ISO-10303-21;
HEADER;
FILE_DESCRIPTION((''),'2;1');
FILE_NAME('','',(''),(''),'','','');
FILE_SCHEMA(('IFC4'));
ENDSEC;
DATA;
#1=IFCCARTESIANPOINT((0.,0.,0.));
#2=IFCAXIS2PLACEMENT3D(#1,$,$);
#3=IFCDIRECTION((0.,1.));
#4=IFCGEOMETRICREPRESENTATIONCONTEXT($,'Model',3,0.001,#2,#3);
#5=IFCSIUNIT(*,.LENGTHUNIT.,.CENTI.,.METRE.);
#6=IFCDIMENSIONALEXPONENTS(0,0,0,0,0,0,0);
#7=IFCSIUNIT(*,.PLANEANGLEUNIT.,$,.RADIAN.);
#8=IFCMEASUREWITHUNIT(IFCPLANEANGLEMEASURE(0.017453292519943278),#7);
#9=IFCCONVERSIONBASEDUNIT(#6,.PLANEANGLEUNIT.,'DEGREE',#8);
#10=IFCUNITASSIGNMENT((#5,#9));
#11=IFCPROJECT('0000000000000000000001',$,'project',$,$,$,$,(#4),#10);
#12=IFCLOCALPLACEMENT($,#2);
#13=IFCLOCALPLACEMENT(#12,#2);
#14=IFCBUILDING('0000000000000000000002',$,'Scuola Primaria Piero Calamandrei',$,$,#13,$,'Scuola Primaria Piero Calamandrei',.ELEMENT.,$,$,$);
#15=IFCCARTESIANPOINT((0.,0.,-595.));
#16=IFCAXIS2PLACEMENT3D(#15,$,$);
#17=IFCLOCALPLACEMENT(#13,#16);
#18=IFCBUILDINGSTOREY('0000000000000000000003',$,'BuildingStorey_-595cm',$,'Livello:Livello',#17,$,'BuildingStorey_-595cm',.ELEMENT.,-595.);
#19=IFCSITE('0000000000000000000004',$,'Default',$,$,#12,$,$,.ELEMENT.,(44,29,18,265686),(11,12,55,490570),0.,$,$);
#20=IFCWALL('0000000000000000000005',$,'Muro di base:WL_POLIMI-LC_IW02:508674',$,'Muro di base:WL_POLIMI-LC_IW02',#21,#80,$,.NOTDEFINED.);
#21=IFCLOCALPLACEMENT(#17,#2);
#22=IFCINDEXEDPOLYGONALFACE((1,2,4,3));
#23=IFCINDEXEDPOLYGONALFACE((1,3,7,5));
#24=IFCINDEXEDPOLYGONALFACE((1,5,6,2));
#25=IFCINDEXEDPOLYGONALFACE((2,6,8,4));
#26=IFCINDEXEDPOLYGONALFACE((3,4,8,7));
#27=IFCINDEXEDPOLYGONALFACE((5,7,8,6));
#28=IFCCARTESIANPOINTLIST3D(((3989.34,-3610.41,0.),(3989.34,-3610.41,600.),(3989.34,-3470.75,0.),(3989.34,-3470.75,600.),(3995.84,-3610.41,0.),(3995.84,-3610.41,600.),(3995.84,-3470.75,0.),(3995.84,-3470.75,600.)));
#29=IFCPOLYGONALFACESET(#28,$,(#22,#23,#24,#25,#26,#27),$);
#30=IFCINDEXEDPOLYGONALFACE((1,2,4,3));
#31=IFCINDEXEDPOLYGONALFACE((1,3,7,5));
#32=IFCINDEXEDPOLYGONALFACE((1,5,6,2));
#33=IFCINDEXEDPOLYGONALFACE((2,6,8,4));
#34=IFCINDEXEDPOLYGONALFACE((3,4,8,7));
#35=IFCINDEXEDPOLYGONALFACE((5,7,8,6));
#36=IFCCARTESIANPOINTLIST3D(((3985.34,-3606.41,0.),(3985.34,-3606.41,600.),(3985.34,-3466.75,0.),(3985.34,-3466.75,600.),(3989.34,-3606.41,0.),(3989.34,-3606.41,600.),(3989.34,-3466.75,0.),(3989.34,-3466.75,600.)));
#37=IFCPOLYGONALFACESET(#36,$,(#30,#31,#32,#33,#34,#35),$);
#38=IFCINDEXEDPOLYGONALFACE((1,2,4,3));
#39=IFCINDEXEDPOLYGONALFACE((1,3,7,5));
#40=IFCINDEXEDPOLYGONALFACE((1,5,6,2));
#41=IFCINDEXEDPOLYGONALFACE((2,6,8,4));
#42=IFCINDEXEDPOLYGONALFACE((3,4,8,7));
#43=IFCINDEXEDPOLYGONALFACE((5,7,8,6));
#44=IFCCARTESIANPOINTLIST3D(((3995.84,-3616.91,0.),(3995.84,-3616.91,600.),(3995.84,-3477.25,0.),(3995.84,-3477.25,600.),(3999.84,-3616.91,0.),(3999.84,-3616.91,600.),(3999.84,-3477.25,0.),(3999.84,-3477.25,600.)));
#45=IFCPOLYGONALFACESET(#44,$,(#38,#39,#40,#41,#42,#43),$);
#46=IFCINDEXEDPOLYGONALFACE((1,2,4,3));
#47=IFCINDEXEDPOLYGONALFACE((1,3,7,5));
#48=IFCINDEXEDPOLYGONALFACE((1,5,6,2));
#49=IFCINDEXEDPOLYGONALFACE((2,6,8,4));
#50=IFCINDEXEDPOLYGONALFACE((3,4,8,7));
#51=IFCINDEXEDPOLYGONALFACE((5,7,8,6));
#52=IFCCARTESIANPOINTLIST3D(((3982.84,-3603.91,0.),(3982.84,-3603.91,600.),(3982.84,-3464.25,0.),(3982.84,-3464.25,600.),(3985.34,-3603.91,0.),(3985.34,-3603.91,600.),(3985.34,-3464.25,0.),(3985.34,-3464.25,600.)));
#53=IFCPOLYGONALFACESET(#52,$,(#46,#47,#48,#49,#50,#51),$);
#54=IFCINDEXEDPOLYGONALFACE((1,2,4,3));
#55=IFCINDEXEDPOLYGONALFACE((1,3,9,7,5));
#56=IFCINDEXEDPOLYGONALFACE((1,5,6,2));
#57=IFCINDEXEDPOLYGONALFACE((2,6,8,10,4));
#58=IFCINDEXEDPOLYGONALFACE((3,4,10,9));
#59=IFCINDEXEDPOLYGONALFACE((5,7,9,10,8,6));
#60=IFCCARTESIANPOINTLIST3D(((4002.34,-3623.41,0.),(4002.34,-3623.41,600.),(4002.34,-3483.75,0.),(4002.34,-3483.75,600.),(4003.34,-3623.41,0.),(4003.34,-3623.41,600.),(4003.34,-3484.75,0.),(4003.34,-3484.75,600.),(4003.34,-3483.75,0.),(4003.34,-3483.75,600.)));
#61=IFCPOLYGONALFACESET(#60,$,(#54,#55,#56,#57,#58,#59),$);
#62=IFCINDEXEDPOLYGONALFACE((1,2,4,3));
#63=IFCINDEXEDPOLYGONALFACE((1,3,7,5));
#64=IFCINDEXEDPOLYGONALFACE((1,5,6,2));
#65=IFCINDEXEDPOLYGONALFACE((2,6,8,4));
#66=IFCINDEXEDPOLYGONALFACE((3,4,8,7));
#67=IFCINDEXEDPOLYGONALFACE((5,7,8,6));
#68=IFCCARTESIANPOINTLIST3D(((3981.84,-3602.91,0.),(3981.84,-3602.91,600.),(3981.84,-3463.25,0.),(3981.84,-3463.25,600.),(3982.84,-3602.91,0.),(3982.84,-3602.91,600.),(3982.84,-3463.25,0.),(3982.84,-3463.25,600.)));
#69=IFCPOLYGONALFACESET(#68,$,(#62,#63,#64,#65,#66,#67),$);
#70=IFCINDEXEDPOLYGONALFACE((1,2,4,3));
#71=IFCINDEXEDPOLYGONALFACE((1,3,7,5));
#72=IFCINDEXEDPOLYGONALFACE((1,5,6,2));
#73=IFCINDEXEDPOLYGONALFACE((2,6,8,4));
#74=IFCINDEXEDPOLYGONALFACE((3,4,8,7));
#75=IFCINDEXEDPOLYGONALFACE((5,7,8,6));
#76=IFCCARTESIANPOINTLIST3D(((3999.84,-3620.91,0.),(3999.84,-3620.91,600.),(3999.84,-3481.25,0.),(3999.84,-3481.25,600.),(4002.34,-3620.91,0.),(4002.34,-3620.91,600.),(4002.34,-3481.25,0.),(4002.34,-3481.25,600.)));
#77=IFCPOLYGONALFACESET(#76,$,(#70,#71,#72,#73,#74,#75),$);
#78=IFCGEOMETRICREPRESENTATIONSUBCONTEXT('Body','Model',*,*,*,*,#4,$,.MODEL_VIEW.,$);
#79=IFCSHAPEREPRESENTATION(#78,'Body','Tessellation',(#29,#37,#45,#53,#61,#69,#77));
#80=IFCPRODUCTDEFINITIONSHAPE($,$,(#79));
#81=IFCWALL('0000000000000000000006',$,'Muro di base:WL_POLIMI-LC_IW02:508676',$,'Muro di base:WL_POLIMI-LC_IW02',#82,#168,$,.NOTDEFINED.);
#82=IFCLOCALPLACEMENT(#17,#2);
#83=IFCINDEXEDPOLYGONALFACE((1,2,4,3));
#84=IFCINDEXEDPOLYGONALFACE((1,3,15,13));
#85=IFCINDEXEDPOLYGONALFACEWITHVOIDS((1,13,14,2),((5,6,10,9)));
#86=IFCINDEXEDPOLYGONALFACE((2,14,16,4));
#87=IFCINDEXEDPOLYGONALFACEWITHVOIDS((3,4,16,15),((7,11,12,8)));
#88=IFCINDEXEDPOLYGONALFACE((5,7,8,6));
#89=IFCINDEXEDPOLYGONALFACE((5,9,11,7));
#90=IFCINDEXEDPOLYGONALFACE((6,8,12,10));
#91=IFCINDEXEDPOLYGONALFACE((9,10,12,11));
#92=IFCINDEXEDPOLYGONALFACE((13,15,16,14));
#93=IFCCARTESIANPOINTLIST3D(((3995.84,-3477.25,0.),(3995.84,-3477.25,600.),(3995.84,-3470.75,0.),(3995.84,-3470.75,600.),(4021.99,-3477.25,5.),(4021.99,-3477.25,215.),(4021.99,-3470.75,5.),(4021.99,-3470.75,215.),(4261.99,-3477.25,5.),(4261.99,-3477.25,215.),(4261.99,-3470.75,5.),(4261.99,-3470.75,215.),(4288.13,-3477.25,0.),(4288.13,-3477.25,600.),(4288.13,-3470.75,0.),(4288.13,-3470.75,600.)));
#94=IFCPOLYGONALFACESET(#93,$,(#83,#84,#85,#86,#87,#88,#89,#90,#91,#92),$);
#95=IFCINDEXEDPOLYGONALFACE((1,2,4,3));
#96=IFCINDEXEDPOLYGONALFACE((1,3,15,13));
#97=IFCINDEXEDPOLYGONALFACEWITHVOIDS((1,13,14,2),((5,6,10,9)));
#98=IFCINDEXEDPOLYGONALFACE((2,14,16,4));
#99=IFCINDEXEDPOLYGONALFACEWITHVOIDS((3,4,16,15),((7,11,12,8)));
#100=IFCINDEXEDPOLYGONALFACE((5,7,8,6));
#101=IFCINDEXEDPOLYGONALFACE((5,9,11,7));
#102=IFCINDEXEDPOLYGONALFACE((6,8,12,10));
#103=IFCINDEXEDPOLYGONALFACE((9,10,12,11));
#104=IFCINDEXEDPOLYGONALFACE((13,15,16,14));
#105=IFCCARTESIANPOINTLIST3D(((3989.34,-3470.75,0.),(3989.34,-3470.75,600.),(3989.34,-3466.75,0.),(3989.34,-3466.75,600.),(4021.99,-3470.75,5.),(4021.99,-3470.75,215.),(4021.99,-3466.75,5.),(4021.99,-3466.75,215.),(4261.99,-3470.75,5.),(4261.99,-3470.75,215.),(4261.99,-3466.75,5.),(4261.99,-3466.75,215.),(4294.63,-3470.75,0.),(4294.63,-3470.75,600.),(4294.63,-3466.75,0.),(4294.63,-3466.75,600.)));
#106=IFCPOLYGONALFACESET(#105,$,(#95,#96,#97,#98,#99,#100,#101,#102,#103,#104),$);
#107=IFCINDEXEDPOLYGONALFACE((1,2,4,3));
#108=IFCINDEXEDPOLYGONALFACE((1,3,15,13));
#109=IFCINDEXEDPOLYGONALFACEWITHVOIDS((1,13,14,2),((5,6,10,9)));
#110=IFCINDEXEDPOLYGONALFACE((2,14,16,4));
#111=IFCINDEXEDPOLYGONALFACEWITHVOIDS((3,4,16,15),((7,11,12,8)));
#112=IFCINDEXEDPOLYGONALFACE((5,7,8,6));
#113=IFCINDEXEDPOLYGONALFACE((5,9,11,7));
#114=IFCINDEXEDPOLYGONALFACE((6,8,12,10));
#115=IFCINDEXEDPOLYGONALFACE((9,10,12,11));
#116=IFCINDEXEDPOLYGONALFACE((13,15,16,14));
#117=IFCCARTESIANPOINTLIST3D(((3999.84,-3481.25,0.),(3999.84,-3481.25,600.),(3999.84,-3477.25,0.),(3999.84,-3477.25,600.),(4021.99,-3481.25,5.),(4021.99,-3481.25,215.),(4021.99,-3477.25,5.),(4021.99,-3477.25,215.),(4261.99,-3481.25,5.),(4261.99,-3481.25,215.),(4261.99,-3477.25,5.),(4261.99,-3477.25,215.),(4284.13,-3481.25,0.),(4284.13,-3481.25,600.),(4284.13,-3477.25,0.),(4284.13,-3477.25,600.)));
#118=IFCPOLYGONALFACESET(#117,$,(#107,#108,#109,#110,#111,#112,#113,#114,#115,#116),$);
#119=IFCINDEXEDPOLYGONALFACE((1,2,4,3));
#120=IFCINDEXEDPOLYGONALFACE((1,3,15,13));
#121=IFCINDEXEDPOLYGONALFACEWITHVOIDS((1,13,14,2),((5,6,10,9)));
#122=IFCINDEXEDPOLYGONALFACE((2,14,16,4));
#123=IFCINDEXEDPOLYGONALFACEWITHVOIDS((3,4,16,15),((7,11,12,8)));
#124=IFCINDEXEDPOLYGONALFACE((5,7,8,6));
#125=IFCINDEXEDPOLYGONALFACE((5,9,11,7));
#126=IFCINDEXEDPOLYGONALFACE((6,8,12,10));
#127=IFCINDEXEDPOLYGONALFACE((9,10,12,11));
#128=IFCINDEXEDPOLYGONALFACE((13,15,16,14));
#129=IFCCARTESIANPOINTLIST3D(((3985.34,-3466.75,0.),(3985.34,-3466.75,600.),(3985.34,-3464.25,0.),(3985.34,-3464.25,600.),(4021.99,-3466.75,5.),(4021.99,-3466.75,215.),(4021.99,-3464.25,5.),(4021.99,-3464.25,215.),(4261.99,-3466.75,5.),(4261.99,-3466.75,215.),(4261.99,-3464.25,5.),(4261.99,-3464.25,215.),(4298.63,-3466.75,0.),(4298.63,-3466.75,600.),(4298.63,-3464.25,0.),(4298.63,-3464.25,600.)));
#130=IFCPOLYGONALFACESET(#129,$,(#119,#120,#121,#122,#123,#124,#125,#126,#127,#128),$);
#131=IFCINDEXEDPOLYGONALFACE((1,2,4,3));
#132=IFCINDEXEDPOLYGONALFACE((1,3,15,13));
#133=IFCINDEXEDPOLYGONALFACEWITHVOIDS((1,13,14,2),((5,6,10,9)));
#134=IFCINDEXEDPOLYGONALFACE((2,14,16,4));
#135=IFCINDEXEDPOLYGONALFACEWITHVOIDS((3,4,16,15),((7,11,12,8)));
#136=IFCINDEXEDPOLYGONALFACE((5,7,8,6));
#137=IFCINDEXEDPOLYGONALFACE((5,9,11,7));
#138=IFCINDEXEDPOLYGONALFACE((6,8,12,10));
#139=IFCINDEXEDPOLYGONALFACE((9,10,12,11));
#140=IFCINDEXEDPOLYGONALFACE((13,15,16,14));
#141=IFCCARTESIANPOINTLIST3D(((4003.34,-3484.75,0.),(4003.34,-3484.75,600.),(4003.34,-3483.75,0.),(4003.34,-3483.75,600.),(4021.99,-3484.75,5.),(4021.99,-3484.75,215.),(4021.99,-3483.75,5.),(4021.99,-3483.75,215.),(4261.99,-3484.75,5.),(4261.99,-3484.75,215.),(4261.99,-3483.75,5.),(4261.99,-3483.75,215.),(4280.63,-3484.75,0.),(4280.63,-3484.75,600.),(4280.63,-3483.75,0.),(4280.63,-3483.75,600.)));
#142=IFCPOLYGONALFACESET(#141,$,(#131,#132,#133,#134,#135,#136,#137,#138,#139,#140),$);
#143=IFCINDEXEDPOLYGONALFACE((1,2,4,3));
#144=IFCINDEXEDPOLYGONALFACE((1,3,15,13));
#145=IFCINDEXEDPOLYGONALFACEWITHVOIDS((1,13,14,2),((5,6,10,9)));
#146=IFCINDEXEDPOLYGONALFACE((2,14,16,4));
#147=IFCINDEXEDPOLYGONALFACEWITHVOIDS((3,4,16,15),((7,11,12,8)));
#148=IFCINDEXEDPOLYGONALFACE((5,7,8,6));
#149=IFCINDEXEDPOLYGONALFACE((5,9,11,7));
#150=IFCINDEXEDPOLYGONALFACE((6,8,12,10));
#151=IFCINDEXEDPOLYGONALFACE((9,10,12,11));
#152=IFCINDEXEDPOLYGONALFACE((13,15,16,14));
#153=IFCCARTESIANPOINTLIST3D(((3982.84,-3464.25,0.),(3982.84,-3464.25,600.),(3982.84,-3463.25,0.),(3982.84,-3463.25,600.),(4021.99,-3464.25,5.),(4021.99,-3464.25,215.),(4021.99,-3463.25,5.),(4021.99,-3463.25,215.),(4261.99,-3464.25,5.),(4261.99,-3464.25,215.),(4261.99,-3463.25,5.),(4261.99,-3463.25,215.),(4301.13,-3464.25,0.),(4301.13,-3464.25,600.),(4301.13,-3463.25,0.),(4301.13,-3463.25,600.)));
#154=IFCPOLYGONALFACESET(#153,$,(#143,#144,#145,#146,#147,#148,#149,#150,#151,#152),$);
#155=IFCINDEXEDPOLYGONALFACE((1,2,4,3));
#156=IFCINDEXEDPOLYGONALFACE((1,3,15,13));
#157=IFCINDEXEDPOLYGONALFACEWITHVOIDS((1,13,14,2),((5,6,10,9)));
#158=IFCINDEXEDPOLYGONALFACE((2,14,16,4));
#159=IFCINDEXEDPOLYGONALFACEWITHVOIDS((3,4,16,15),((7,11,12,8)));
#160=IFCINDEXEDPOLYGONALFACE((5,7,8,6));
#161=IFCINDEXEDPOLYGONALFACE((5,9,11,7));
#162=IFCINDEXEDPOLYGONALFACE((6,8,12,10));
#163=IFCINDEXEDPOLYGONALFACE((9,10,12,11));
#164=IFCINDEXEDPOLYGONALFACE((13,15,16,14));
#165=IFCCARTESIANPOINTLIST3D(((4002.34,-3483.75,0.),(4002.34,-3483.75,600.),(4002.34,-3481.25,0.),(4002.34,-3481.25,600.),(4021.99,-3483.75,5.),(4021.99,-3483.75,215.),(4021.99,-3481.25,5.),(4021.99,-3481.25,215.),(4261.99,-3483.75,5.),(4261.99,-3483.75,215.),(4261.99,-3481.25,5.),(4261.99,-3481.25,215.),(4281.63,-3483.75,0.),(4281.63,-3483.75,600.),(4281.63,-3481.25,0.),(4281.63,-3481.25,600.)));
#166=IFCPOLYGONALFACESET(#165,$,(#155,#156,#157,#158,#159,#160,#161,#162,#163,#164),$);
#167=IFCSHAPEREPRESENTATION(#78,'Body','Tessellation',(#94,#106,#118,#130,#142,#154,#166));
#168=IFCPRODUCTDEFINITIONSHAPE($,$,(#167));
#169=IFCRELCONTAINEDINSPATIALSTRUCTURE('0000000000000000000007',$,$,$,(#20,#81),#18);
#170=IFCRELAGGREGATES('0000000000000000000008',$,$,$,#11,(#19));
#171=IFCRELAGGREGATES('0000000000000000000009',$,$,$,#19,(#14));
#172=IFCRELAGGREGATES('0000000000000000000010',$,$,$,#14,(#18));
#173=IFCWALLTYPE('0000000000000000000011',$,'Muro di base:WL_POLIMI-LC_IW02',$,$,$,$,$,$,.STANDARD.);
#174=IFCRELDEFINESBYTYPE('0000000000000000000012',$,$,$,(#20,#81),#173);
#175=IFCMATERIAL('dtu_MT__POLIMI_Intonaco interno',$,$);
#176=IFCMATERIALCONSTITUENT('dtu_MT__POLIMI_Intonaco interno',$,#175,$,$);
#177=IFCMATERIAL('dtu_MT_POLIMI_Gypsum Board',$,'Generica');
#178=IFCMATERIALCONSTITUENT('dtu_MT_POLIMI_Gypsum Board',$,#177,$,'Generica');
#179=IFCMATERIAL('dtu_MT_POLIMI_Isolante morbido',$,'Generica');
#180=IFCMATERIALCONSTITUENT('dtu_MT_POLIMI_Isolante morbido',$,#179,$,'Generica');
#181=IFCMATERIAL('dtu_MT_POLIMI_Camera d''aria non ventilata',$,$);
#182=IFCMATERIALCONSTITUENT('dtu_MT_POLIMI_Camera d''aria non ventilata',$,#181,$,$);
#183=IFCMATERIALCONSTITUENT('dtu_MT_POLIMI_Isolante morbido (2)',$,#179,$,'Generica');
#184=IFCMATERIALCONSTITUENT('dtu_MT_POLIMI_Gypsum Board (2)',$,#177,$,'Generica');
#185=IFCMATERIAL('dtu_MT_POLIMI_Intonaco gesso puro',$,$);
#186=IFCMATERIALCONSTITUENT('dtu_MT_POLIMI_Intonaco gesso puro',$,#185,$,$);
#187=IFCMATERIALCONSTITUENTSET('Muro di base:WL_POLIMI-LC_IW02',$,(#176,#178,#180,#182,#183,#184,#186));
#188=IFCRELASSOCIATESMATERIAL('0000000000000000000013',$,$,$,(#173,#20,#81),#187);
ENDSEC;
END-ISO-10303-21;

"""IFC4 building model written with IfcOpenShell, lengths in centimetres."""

from ifc_helpers import new_model, entity, si_unit, converted_unit, direction, frame, origin, place, context, subcontext, project, spatial, indexed_curve, outline, extrude, material, constituent, constituent_set, type_object, element, save


model = new_model("IFC4")

# Units and contexts
model_context = context("Model", 3, precision=0.001, world=origin(), true_north=direction((0.0, 1.0)))
body_context = subcontext(model_context, "Body", "Model", "MODEL_VIEW")
ifc_project = project(units=[si_unit("LENGTHUNIT", "METRE", prefix="CENTI"), converted_unit("PLANEANGLEUNIT", "DEGREE", entity("IfcPlaneAngleMeasure", 0.017453292519943278), si_unit("PLANEANGLEUNIT", "RADIAN"), dimensions=[0, 0, 0, 0, 0, 0, 0])], contexts=[model_context])

# Site, building, storey
site_placement = place(None, origin())
site = spatial("IfcSite", under=ifc_project, at=site_placement, Name="Default", CompositionType="ELEMENT", RefLatitude=(44, 29, 18, 265686), RefLongitude=(11, 12, 55, 490570), RefElevation=0.0)
building_placement = place(site_placement, origin())
building = spatial("IfcBuilding", under=site, at=building_placement, Name="Scuola Primaria Piero Calamandrei", LongName="Scuola Primaria Piero Calamandrei", CompositionType="ELEMENT")
storey_placement = place(building_placement, frame((0.0, 0.0, -595.0)))
storey = spatial("IfcBuildingStorey", under=building, at=storey_placement, Name="BuildingStorey_-595cm", ObjectType="Livello:Livello", LongName="BuildingStorey_-595cm", CompositionType="ELEMENT", Elevation=-595.0)

# Shared definitions
ifc_material_1 = material(Name="dtu_MT__POLIMI_Intonaco interno")
ifc_constituent_1 = constituent(ifc_material_1, Name="dtu_MT__POLIMI_Intonaco interno")
ifc_material_2 = material(Name="dtu_MT_POLIMI_Gypsum Board", Category="Generica")
ifc_constituent_2 = constituent(ifc_material_2, Name="dtu_MT_POLIMI_Gypsum Board", Category="Generica")
ifc_material_3 = material(Name="dtu_MT_POLIMI_Isolante morbido", Category="Generica")
ifc_constituent_3 = constituent(ifc_material_3, Name="dtu_MT_POLIMI_Isolante morbido", Category="Generica")
ifc_material_4 = material(Name="dtu_MT_POLIMI_Camera d'aria non ventilata")
ifc_constituent_4 = constituent(ifc_material_4, Name="dtu_MT_POLIMI_Camera d'aria non ventilata")
ifc_constituent_5 = constituent(ifc_material_3, Name="dtu_MT_POLIMI_Isolante morbido (2)", Category="Generica")
ifc_constituent_6 = constituent(ifc_material_2, Name="dtu_MT_POLIMI_Gypsum Board (2)", Category="Generica")
ifc_material_5 = material(Name="dtu_MT_POLIMI_Intonaco gesso puro")
ifc_constituent_7 = constituent(ifc_material_5, Name="dtu_MT_POLIMI_Intonaco gesso puro")
ifc_constituent_set_1 = constituent_set(constituents=[ifc_constituent_1, ifc_constituent_2, ifc_constituent_3, ifc_constituent_4, ifc_constituent_5, ifc_constituent_6, ifc_constituent_7], Name="Muro di base:WL_POLIMI-LC_IW02")
wall_type_1 = type_object("IfcWallType", Name="Muro di base:WL_POLIMI-LC_IW02", PredefinedType="STANDARD", material=ifc_constituent_set_1)

# Wall
wall_1_placement = place(storey_placement, frame((3992.59, -3602.91, 0.0), z_axis=(0.0, 0.0, 1.0), x_axis=(0.0, 1.0, 0.0)))
element("IfcWall", 1, at=wall_1_placement, inside=storey, type_object=wall_type_1, material=ifc_constituent_set_1, Name="Muro di base:WL_POLIMI-LC_IW02:508674", ObjectType="Muro di base:WL_POLIMI-LC_IW02", PredefinedType="NOTDEFINED", context=body_context, shape_type="SweptSolid", body=[
    extrude(outline(indexed_curve([(-69.83, -3.25), (69.83, -3.25), (69.83, 3.25), (-69.83, 3.25), (-69.83, -3.25)], self_intersect=False)), frame((62.33, 0.0, 0.0)), (0.0, 0.0, 1.0), 600.0),
    extrude(outline(indexed_curve([(-69.83, -2.0), (69.83, -2.0), (69.83, 2.0), (-69.83, 2.0), (-69.83, -2.0)], self_intersect=False)), frame((66.33, 5.25, 0.0)), (0.0, 0.0, 1.0), 600.0),
    extrude(outline(indexed_curve([(-69.83, -2.0), (69.83, -2.0), (69.83, 2.0), (-69.83, 2.0), (-69.83, -2.0)], self_intersect=False)), frame((55.83, -5.25, 0.0)), (0.0, 0.0, 1.0), 600.0),
    extrude(outline(indexed_curve([(-69.83, -1.25), (69.83, -1.25), (69.83, 1.25), (-69.83, 1.25), (-69.83, -1.25)], self_intersect=False)), frame((68.83, 8.5, 0.0)), (0.0, 0.0, 1.0), 600.0),
    extrude(outline(indexed_curve([(55.06, -0.4), (56.06, -0.4), (56.06, 0.6), (-83.59, 0.6), (-83.59, -0.4), (55.06, -0.4)], self_intersect=False)), frame((63.09, -10.35, 0.0)), (0.0, 0.0, 1.0), 600.0),
    extrude(outline(indexed_curve([(-0.5, -69.83), (0.5, -69.83), (0.5, 69.83), (-0.5, 69.83), (-0.5, -69.83)], self_intersect=False)), frame((69.83, 10.25, 0.0), z_axis=(0.0, 0.0, 1.0), x_axis=(0.0, -1.0, 0.0)), (0.0, 0.0, 1.0), 600.0),
    extrude(outline(indexed_curve([(-69.83, -1.25), (69.83, -1.25), (69.83, 1.25), (-69.83, 1.25), (-69.83, -1.25)], self_intersect=False)), frame((51.83, -8.5, 0.0)), (0.0, 0.0, 1.0), 600.0),
])

# Wall, opening
wall_2_placement = place(storey_placement, frame((4003.34, -3474.0, 0.0)))
wall_2 = element("IfcWall", 2, at=wall_2_placement, inside=storey, type_object=wall_type_1, material=ifc_constituent_set_1, Name="Muro di base:WL_POLIMI-LC_IW02:508676", ObjectType="Muro di base:WL_POLIMI-LC_IW02", PredefinedType="NOTDEFINED", context=body_context, shape_type="SweptSolid", body=[
    extrude(outline(indexed_curve([(-300.0, -146.14), (300.0, -146.14), (300.0, 146.14), (-300.0, 146.14), (-300.0, -146.14)], self_intersect=False), holes=[indexed_curve([(-295.0, -120.0), (-295.0, 120.0), (-85.0, 120.0), (-85.0, -120.0), (-295.0, -120.0)], self_intersect=False)]), frame((138.64, -3.25, 300.0), z_axis=(0.0, 1.0, 0.0), x_axis=(0.0, 0.0, 1.0)), (0.0, 0.0, 1.0), 6.5),
    extrude(outline(indexed_curve([(-300.0, -152.64), (300.0, -152.64), (300.0, 152.64), (-300.0, 152.64), (-300.0, -152.64)], self_intersect=False), holes=[indexed_curve([(-295.0, -120.0), (-295.0, 120.0), (-85.0, 120.0), (-85.0, -120.0), (-295.0, -120.0)], self_intersect=False)]), frame((138.64, 3.25, 300.0), z_axis=(0.0, 1.0, 0.0), x_axis=(0.0, 0.0, 1.0)), (0.0, 0.0, 1.0), 4.0),
    extrude(outline(indexed_curve([(-300.0, -142.14), (300.0, -142.14), (300.0, 142.14), (-300.0, 142.14), (-300.0, -142.14)], self_intersect=False), holes=[indexed_curve([(-295.0, -120.0), (-295.0, 120.0), (-85.0, 120.0), (-85.0, -120.0), (-295.0, -120.0)], self_intersect=False)]), frame((138.64, -7.25, 300.0), z_axis=(0.0, 1.0, 0.0), x_axis=(0.0, 0.0, 1.0)), (0.0, 0.0, 1.0), 4.0),
    extrude(outline(indexed_curve([(-300.0, -156.64), (300.0, -156.64), (300.0, 156.64), (-300.0, 156.64), (-300.0, -156.64)], self_intersect=False), holes=[indexed_curve([(-295.0, -120.0), (-295.0, 120.0), (-85.0, 120.0), (-85.0, -120.0), (-295.0, -120.0)], self_intersect=False)]), frame((138.64, 7.25, 300.0), z_axis=(0.0, 1.0, 0.0), x_axis=(0.0, 0.0, 1.0)), (0.0, 0.0, 1.0), 2.5),
    extrude(outline(indexed_curve([(-300.0, -138.64), (300.0, -138.64), (300.0, 138.64), (-300.0, 138.64), (-300.0, -138.64)], self_intersect=False), holes=[indexed_curve([(-85.0, -120.0), (-295.0, -120.0), (-295.0, 120.0), (-85.0, 120.0), (-85.0, -120.0)], self_intersect=False)]), frame((138.64, -10.75, 300.0), z_axis=(0.0, 1.0, 0.0), x_axis=(0.0, 0.0, 1.0)), (0.0, 0.0, 1.0), 1.0),
    extrude(outline(indexed_curve([(-300.0, -159.14), (300.0, -159.14), (300.0, 159.14), (-300.0, 159.14), (-300.0, -159.14)], self_intersect=False), holes=[indexed_curve([(-295.0, -120.0), (-295.0, 120.0), (-85.0, 120.0), (-85.0, -120.0), (-295.0, -120.0)], self_intersect=False)]), frame((138.64, 9.75, 300.0), z_axis=(0.0, 1.0, 0.0), x_axis=(0.0, 0.0, 1.0)), (0.0, 0.0, 1.0), 1.0),
    extrude(outline(indexed_curve([(-300.0, -139.64), (300.0, -139.64), (300.0, 139.64), (-300.0, 139.64), (-300.0, -139.64)], self_intersect=False), holes=[indexed_curve([(-295.0, -120.0), (-295.0, 120.0), (-85.0, 120.0), (-85.0, -120.0), (-295.0, -120.0)], self_intersect=False)]), frame((138.64, -9.75, 300.0), z_axis=(0.0, 1.0, 0.0), x_axis=(0.0, 0.0, 1.0)), (0.0, 0.0, 1.0), 2.5),
])
opening_1_placement = place(wall_2_placement, frame((258.64, 10.75, 5.0)))
element("IfcOpeningElement", 3, at=opening_1_placement, cuts=wall_2, PredefinedType="OPENING", context=body_context, shape_type="SweptSolid", body=[
    extrude(outline(indexed_curve([(210.0, 240.0), (0.0, 240.0), (0.0, 0.0), (210.0, 0.0), (210.0, 240.0)], self_intersect=False)), frame((0.0, 0.0, 0.0), z_axis=(0.0, -1.0, 0.0), x_axis=(0.0, 0.0, 1.0)), (0.0, 0.0, 1.0), 21.5),
])

save(model, "model.ifc")
